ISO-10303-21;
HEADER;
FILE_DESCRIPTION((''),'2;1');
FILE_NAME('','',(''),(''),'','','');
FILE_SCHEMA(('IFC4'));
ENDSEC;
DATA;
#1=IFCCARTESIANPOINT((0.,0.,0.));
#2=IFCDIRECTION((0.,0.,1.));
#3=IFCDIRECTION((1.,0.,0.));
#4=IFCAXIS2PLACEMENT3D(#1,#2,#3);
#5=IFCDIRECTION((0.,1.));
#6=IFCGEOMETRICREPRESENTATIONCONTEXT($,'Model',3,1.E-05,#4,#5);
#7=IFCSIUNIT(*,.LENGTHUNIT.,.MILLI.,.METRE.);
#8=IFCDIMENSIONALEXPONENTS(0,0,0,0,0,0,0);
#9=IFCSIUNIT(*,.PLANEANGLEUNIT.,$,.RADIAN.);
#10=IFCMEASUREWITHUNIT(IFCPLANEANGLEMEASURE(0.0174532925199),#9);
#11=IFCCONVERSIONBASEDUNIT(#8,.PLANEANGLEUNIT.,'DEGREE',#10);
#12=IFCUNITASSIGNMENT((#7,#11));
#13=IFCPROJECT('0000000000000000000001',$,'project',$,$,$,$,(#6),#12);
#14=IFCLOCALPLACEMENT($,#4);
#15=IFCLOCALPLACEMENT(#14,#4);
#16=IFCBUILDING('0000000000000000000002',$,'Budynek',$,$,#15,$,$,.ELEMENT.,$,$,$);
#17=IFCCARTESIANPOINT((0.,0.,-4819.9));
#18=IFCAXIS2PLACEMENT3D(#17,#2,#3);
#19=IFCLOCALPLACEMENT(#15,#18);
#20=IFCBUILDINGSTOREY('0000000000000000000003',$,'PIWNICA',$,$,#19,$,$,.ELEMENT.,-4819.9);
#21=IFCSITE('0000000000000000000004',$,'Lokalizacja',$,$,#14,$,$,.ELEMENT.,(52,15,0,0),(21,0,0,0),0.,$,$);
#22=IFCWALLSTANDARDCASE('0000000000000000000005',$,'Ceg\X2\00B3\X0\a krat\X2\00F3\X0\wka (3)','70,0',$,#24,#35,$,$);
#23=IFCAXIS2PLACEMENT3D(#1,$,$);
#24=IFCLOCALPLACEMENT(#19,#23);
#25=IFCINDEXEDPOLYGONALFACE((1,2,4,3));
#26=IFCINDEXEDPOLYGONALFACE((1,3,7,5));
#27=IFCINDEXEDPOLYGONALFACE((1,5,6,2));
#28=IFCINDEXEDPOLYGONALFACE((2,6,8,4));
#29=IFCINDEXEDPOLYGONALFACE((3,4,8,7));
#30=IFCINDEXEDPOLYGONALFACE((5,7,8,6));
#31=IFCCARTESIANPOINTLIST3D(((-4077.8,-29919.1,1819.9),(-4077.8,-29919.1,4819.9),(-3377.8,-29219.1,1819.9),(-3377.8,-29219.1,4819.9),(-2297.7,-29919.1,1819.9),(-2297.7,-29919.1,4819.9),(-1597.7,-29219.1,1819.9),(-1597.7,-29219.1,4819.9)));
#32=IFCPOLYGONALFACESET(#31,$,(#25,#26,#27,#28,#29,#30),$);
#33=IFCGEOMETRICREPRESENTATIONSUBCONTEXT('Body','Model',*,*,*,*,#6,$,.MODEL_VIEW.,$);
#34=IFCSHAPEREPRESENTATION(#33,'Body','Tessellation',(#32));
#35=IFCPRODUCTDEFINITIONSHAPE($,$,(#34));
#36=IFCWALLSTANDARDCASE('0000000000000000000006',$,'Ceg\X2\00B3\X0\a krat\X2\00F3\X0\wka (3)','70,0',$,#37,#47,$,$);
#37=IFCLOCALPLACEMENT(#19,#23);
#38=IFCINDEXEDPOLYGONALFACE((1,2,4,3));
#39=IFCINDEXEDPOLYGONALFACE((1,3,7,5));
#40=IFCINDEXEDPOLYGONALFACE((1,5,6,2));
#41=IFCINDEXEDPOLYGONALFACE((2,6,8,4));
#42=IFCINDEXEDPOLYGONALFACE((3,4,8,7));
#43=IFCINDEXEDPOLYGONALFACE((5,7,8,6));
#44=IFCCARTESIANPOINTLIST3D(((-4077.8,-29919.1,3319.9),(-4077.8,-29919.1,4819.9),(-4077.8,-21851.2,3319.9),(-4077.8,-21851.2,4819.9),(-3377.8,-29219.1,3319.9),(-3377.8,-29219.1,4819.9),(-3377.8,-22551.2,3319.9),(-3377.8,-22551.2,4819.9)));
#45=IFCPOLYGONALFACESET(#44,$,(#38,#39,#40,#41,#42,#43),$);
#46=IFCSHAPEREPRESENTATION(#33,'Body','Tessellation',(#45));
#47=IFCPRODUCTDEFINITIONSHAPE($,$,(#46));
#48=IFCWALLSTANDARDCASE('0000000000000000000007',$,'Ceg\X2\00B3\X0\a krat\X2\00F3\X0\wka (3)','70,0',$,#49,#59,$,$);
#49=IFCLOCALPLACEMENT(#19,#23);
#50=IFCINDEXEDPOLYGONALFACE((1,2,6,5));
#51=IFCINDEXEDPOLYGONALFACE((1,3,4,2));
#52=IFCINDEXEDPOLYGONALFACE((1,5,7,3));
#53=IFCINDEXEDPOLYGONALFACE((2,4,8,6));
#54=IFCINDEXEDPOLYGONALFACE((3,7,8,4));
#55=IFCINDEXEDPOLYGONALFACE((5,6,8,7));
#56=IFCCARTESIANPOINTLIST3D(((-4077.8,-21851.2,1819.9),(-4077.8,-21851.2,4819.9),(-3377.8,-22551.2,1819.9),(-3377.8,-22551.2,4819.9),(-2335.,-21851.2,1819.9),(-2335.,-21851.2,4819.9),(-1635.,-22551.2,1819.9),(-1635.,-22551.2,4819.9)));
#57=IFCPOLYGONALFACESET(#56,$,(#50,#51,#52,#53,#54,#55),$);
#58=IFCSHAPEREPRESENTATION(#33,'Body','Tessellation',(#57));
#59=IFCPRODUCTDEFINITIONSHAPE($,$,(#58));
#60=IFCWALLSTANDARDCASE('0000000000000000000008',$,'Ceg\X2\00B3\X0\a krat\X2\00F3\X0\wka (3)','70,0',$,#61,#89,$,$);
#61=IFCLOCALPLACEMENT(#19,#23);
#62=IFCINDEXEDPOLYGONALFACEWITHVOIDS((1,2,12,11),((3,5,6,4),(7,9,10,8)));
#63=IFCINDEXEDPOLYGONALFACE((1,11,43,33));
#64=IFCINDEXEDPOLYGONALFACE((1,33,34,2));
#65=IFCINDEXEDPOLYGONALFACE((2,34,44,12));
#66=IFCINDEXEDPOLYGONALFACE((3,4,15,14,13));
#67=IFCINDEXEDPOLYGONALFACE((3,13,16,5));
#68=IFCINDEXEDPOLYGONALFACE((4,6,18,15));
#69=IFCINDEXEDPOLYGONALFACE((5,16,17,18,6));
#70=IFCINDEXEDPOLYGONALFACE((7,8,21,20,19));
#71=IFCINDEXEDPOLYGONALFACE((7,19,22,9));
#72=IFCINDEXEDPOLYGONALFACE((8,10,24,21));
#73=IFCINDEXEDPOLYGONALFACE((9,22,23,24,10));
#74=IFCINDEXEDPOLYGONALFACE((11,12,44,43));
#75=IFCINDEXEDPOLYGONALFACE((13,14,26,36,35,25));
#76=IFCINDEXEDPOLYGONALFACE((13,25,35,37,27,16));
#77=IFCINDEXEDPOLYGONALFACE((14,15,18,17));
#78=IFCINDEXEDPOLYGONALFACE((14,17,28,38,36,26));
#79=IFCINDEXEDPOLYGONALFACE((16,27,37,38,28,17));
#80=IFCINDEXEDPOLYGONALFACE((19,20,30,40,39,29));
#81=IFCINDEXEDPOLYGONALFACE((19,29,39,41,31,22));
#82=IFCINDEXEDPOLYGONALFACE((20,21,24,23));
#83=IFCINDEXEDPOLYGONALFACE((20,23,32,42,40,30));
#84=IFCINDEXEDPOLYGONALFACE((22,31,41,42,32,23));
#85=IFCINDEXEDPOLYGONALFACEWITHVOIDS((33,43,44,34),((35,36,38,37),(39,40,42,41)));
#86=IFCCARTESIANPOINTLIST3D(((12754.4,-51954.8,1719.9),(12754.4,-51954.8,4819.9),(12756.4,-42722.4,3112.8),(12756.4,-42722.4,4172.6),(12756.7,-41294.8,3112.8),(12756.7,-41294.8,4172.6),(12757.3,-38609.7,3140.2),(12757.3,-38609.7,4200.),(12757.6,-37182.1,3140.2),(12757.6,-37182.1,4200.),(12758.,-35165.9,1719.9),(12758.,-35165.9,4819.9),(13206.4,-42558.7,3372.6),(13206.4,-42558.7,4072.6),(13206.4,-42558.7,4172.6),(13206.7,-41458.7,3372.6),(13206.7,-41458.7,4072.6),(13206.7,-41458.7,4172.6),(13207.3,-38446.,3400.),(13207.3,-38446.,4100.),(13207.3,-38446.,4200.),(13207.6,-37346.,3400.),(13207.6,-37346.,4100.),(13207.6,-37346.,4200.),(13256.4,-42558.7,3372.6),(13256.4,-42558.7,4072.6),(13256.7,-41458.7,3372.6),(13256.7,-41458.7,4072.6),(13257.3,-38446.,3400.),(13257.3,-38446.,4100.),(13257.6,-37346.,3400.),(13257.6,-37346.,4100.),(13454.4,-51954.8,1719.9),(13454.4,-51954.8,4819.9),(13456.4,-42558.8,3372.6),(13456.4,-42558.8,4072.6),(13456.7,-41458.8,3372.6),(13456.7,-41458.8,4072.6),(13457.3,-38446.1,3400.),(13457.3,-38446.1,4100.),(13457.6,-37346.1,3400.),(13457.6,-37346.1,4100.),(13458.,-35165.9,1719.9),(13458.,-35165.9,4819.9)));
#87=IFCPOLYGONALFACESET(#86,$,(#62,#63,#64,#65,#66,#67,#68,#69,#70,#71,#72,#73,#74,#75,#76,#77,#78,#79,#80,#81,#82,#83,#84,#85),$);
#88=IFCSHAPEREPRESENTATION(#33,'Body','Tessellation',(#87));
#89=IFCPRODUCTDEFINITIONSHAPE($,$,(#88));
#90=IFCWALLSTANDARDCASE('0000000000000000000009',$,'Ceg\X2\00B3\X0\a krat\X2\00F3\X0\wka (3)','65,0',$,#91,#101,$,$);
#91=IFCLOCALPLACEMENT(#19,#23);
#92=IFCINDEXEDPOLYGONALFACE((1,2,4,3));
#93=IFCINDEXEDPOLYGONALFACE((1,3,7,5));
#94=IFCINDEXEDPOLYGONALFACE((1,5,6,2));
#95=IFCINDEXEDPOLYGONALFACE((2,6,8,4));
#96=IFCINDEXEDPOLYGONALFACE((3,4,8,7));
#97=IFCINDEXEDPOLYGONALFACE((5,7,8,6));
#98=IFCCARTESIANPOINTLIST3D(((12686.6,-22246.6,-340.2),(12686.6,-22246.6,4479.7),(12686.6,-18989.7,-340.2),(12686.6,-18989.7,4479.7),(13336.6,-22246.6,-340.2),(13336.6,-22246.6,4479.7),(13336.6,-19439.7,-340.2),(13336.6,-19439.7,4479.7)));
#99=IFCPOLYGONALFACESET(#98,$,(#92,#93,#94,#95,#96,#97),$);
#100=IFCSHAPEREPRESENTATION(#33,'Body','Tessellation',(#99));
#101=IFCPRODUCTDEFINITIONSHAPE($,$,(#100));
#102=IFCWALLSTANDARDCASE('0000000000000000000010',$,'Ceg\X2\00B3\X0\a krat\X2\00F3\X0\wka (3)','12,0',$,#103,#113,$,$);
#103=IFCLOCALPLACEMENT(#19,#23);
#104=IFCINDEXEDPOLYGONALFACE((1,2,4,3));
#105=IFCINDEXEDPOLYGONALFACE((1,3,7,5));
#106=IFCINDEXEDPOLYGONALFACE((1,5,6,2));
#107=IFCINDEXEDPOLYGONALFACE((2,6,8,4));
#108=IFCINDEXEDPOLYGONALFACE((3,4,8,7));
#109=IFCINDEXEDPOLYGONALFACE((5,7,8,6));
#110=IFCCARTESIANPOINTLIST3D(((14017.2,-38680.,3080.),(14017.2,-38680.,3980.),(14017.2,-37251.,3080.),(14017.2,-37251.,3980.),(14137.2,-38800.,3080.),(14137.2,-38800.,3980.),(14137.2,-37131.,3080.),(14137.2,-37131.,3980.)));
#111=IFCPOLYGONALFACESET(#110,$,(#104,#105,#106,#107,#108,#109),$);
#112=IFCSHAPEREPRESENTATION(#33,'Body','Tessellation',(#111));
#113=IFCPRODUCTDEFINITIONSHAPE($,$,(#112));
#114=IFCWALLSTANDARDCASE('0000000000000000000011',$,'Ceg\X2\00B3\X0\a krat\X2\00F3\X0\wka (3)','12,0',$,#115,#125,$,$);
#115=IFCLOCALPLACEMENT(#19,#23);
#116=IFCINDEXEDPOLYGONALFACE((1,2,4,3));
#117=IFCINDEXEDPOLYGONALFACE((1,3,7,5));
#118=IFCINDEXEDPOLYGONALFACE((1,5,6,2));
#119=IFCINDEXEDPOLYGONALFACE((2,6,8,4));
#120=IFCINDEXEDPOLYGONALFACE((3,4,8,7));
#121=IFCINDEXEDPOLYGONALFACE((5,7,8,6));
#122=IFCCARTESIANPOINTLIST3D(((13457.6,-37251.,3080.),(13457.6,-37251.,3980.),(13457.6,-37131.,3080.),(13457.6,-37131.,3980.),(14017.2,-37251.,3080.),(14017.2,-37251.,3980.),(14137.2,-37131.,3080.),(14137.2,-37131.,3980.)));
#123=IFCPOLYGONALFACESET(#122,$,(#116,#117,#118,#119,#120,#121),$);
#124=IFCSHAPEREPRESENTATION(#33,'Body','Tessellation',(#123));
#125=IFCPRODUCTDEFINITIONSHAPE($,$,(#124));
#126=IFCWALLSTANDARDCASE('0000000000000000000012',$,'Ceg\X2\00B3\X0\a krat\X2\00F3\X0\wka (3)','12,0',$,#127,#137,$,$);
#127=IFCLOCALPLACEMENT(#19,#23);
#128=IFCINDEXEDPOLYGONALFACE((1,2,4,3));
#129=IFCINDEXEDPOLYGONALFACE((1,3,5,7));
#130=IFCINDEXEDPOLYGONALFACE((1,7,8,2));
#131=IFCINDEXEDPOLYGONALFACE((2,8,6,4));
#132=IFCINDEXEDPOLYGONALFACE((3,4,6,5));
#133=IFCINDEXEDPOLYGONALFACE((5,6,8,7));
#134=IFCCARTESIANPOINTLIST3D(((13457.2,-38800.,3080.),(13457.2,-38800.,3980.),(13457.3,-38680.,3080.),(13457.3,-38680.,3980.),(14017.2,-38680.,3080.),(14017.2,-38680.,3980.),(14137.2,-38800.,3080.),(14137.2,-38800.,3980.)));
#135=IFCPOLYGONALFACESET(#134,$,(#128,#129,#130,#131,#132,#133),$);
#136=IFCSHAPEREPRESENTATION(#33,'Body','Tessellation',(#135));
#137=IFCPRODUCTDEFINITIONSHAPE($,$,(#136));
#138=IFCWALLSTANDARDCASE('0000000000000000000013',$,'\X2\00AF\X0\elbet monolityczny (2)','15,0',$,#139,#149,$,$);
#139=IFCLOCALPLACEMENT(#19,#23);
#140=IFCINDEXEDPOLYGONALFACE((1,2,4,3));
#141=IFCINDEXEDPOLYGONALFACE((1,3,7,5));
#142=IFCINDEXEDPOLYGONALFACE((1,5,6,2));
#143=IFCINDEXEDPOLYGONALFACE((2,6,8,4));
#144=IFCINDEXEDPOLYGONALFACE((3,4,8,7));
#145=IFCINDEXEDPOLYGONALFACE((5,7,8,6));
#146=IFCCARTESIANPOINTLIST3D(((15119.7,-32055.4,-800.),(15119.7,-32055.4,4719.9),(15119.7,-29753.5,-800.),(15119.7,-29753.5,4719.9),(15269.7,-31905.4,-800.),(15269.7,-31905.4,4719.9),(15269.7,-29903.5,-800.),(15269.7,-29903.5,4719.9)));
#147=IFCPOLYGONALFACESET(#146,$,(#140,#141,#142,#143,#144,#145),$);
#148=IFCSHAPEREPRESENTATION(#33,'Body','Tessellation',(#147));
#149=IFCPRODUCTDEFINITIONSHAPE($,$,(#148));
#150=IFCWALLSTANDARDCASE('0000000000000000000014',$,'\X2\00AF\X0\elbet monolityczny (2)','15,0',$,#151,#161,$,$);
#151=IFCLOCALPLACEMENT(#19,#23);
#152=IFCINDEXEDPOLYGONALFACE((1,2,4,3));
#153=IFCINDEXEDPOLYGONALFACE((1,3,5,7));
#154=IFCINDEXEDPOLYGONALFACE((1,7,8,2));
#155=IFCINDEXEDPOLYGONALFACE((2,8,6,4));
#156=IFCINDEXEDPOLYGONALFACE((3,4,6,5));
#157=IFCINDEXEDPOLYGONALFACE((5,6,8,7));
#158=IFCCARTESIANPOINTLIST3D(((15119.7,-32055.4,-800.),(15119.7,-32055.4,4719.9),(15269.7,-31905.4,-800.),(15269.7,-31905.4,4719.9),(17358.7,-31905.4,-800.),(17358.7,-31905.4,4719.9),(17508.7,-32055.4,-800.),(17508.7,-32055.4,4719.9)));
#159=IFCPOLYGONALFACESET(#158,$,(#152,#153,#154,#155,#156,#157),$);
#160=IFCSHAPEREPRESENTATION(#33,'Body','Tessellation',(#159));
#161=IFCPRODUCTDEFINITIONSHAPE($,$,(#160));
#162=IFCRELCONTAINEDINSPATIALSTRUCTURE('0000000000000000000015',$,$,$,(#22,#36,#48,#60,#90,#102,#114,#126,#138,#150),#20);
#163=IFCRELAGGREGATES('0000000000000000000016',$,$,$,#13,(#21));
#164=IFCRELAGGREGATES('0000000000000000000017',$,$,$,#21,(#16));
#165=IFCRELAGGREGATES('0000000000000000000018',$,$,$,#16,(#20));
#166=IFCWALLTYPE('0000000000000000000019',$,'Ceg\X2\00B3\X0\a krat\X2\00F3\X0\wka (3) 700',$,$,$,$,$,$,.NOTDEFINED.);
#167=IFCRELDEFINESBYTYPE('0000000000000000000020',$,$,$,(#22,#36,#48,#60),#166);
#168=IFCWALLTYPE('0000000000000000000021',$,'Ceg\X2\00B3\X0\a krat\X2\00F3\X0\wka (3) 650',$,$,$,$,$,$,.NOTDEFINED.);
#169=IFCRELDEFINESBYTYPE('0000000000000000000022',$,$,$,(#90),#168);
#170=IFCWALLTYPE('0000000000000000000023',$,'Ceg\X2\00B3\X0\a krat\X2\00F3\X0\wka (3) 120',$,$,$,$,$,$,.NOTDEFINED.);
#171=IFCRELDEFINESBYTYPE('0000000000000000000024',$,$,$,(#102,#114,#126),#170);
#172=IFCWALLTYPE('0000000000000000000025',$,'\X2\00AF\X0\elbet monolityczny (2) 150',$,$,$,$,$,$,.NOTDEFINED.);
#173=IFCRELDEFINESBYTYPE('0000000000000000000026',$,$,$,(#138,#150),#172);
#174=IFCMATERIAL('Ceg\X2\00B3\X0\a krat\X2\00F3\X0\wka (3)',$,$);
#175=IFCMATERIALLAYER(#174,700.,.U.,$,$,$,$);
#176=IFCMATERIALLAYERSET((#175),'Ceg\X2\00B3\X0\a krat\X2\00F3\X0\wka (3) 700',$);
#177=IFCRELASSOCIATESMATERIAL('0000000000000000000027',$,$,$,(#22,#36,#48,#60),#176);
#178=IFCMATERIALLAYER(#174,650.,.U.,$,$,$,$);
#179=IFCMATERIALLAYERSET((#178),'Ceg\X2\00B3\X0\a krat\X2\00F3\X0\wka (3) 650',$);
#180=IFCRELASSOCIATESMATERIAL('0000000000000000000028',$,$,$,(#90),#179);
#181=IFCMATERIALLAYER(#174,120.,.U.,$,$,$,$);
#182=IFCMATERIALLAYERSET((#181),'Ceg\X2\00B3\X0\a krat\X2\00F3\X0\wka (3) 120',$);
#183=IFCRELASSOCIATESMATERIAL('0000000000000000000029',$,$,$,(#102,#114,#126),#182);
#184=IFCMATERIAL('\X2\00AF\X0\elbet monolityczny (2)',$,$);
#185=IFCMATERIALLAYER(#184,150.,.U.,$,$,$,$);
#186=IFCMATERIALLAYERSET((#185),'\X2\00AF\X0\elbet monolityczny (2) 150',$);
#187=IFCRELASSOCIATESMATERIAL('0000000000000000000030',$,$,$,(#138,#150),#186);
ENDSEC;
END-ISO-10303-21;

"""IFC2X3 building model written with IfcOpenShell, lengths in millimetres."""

from ifc_helpers import new_model, entity, si_unit, converted_unit, direction, frame, origin_with_axes, origin_2d_with_axis, place, context, subcontext, project, spatial, polyline, rectangle, outline, extrude, material, layer, layer_set, layer_usage, type_object, element, save


model = new_model("IFC2X3")

# Units and contexts
model_context = context("Model", 3, precision=1e-05, world=origin_with_axes(), true_north=direction((0.0, 1.0)))
body_context = subcontext(model_context, "Body", "Model", "MODEL_VIEW")
ifc_project = project(units=[si_unit("LENGTHUNIT", "METRE", prefix="MILLI"), converted_unit("PLANEANGLEUNIT", "DEGREE", entity("IfcPlaneAngleMeasure", 0.0174532925199), si_unit("PLANEANGLEUNIT", "RADIAN"), dimensions=[0, 0, 0, 0, 0, 0, 0])], contexts=[model_context])

# Site, building, storey
site_placement = place(None, origin_with_axes())
site = spatial("IfcSite", under=ifc_project, at=site_placement, Name="Lokalizacja", CompositionType="ELEMENT", RefLatitude=(52, 15, 0, 0), RefLongitude=(21, 0, 0, 0), RefElevation=0.0)
building_placement = place(site_placement, origin_with_axes())
building = spatial("IfcBuilding", under=site, at=building_placement, Name="Budynek", CompositionType="ELEMENT")
storey_placement = place(building_placement, frame((0.0, 0.0, -4819.9), z_axis=(0.0, 0.0, 1.0), x_axis=(1.0, 0.0, 0.0)))
storey = spatial("IfcBuildingStorey", under=building, at=storey_placement, Name="PIWNICA", CompositionType="ELEMENT", Elevation=-4819.9)

# Shared definitions
ifc_material_1 = material(Name="¯elbet monolityczny (2)")

# Shared definitions
ifc_material_2 = material(Name="Ceg³a kratówka (3)")

# Walls
ifc_layer_1 = layer(ifc_material_2, 700.0, ventilated="UNKNOWN")
ifc_layer_set_1 = layer_set([ifc_layer_1], Name="Ceg³a kratówka (3) 700")
wall_type_1 = type_object("IfcWallType", Name="Ceg³a kratówka (3) 700", PredefinedType="NOTDEFINED")
ifc_layer_usage_1 = layer_usage(ifc_layer_set_1, "AXIS2", "NEGATIVE", 0.0)
wall_1_placement = place(storey_placement, frame((-3377.8, -29219.1, 1819.9), z_axis=(0.0, 0.0, 1.0), x_axis=(1.0, 0.0, 0.0)))
element("IfcWallStandardCase", 1, at=wall_1_placement, inside=storey, type_object=wall_type_1, material=ifc_layer_usage_1, Name="Ceg³a kratówka (3)", Description="70,0", context=body_context, shape_type="SweptSolid", body=[
    extrude(outline(polyline([(-700.0, -700.0), (1080.0, -700.0), (1780.0, 0.0), (0.0, 0.0), (-700.0, -700.0)])), origin_with_axes(), (0.0, 0.0, 1.0), 3000.0),
])
ifc_layer_usage_2 = layer_usage(ifc_layer_set_1, "AXIS2", "NEGATIVE", 0.0)
wall_2_placement = place(storey_placement, frame((-3377.8, -22551.2, 3319.9), z_axis=(0.0, 0.0, 1.0), x_axis=(0.0, -1.0, 0.0)))
element("IfcWallStandardCase", 2, at=wall_2_placement, inside=storey, type_object=wall_type_1, material=ifc_layer_usage_2, Name="Ceg³a kratówka (3)", Description="70,0", context=body_context, shape_type="SweptSolid", body=[
    extrude(outline(polyline([(-700.0, -700.0), (7367.9, -700.0), (6667.9, 0.0), (0.0, 0.0), (-700.0, -700.0)])), origin_with_axes(), (0.0, 0.0, 1.0), 1500.0),
])
ifc_layer_usage_3 = layer_usage(ifc_layer_set_1, "AXIS2", "NEGATIVE", 0.0)
wall_3_placement = place(storey_placement, frame((-1635.0, -22551.2, 1819.9), z_axis=(0.0, 0.0, 1.0), x_axis=(-1.0, 0.0, 0.0)))
element("IfcWallStandardCase", 3, at=wall_3_placement, inside=storey, type_object=wall_type_1, material=ifc_layer_usage_3, Name="Ceg³a kratówka (3)", Description="70,0", context=body_context, shape_type="SweptSolid", body=[
    extrude(outline(polyline([(700.0, -700.0), (2442.8, -700.0), (1742.8, 0.0), (0.0, 0.0), (700.0, -700.0)])), origin_with_axes(), (0.0, 0.0, 1.0), 3000.0),
])

# Wall, openings
ifc_layer_usage_4 = layer_usage(ifc_layer_set_1, "AXIS2", "POSITIVE", 0.0)
wall_4_placement = place(storey_placement, frame((12758.1, -34765.9, 1719.9), z_axis=(0.0, 0.0, 1.0), x_axis=(-0.000214, -1.0, 0.0)))
wall_4 = element("IfcWallStandardCase", 4, at=wall_4_placement, inside=storey, type_object=wall_type_1, material=ifc_layer_usage_4, Name="Ceg³a kratówka (3)", Description="70,0", context=body_context, shape_type="SweptSolid", body=[
    extrude(outline(polyline([(400.0, 0.0), (17188.9, 0.0), (17188.8, 700.0), (399.9, 700.0), (400.0, 0.0)])), origin_with_axes(), (0.0, 0.0, 1.0), 3100.0),
])
opening_1_placement = place(wall_4_placement, frame((7242.7, 0.0, 1652.7), z_axis=(0.0, 0.0, 1.0), x_axis=(1.0, 0.0, 0.0)))
element("IfcOpeningElement", 5, at=opening_1_placement, cuts=wall_4, context=body_context, shape_type="SweptSolid", body=[
    extrude(rectangle(XDim=1100.0, YDim=700.0, at=origin_2d_with_axis()), frame((0.0, 500.0, 350.0), z_axis=(0.0, -1.0, 0.0), x_axis=(-1.0, 0.0, 0.0)), (0.0, 0.0, -1.0), 900.0),
    extrude(rectangle(XDim=1100.0, YDim=700.0, at=origin_2d_with_axis()), frame((0.0, 500.0, 350.0), z_axis=(0.0, -1.0, 0.0), x_axis=(-1.0, 0.0, 0.0)), (0.0, 0.0, 1.0), 50.0),
    extrude(rectangle(XDim=1100.0, YDim=800.0, at=origin_2d_with_axis()), frame((0.0, 450.0, 400.0), z_axis=(0.0, 1.0, 0.0), x_axis=(-1.0, 0.0, 0.0)), (0.34202, 0.0, -0.939693), 700.0),
    extrude(rectangle(XDim=1100.0, YDim=800.0, at=origin_2d_with_axis()), frame((0.0, 450.0, 400.0), z_axis=(0.0, 1.0, 0.0), x_axis=(-1.0, 0.0, 0.0)), (-0.34202, 0.0, -0.939693), 700.0),
    extrude(rectangle(XDim=1100.0, YDim=800.0, at=origin_2d_with_axis()), frame((0.0, 450.0, 400.0), z_axis=(0.0, 1.0, 0.0), x_axis=(-1.0, 0.0, 0.0)), (0.300627, -0.476871, -0.825965), 1479.9),
    extrude(rectangle(XDim=1100.0, YDim=800.0, at=origin_2d_with_axis()), frame((0.0, 450.0, 400.0), z_axis=(0.0, 1.0, 0.0), x_axis=(-1.0, 0.0, 0.0)), (-0.300627, -0.476871, -0.825965), 1479.9),
])
opening_2_placement = place(wall_4_placement, frame((3130.0, 0.0, 1680.1), z_axis=(0.0, 0.0, 1.0), x_axis=(1.0, 0.0, 0.0)))
element("IfcOpeningElement", 6, at=opening_2_placement, cuts=wall_4, context=body_context, shape_type="SweptSolid", body=[
    extrude(rectangle(XDim=1100.0, YDim=700.0, at=origin_2d_with_axis()), frame((0.0, 500.0, 350.0), z_axis=(0.0, -1.0, 0.0), x_axis=(-1.0, 0.0, 0.0)), (0.0, 0.0, -1.0), 900.0),
    extrude(rectangle(XDim=1100.0, YDim=700.0, at=origin_2d_with_axis()), frame((0.0, 500.0, 350.0), z_axis=(0.0, -1.0, 0.0), x_axis=(-1.0, 0.0, 0.0)), (0.0, 0.0, 1.0), 50.0),
    extrude(rectangle(XDim=1100.0, YDim=800.0, at=origin_2d_with_axis()), frame((0.0, 450.0, 400.0), z_axis=(0.0, 1.0, 0.0), x_axis=(-1.0, 0.0, 0.0)), (0.34202, 0.0, -0.939693), 700.0),
    extrude(rectangle(XDim=1100.0, YDim=800.0, at=origin_2d_with_axis()), frame((0.0, 450.0, 400.0), z_axis=(0.0, 1.0, 0.0), x_axis=(-1.0, 0.0, 0.0)), (-0.34202, 0.0, -0.939693), 700.0),
    extrude(rectangle(XDim=1100.0, YDim=800.0, at=origin_2d_with_axis()), frame((0.0, 450.0, 400.0), z_axis=(0.0, 1.0, 0.0), x_axis=(-1.0, 0.0, 0.0)), (0.300627, -0.476871, -0.825965), 1479.9),
    extrude(rectangle(XDim=1100.0, YDim=800.0, at=origin_2d_with_axis()), frame((0.0, 450.0, 400.0), z_axis=(0.0, 1.0, 0.0), x_axis=(-1.0, 0.0, 0.0)), (-0.300627, -0.476871, -0.825965), 1479.9),
])

# Walls
ifc_layer_2 = layer(ifc_material_2, 650.0, ventilated="UNKNOWN")
ifc_layer_set_2 = layer_set([ifc_layer_2], Name="Ceg³a kratówka (3) 650")
ifc_layer_usage_5 = layer_usage(ifc_layer_set_2, "AXIS2", "NEGATIVE", 0.0)
wall_type_2 = type_object("IfcWallType", Name="Ceg³a kratówka (3) 650", PredefinedType="NOTDEFINED")
wall_5_placement = place(storey_placement, frame((12686.6, -22696.6, -340.2), z_axis=(0.0, 0.0, 1.0), x_axis=(0.0, 1.0, 0.0)))
element("IfcWallStandardCase", 7, at=wall_5_placement, inside=storey, type_object=wall_type_2, material=ifc_layer_usage_5, Name="Ceg³a kratówka (3)", Description="65,0", context=body_context, shape_type="SweptSolid", body=[
    extrude(outline(polyline([(450.0, -650.0), (3256.9, -650.0), (3706.9, 0.0), (450.0, 0.0), (450.0, -650.0)])), origin_with_axes(), (0.0, 0.0, 1.0), 4819.9),
])
ifc_layer_3 = layer(ifc_material_2, 120.0, ventilated="UNKNOWN")
ifc_layer_set_3 = layer_set([ifc_layer_3], Name="Ceg³a kratówka (3) 120")
ifc_layer_usage_6 = layer_usage(ifc_layer_set_3, "AXIS2", "NEGATIVE", 0.0)
wall_type_3 = type_object("IfcWallType", Name="Ceg³a kratówka (3) 120", PredefinedType="NOTDEFINED")
wall_6_placement = place(storey_placement, frame((14017.2, -38680.0, 3080.0), z_axis=(0.0, 0.0, 1.0), x_axis=(0.0, 1.0, 0.0)))
element("IfcWallStandardCase", 8, at=wall_6_placement, inside=storey, type_object=wall_type_3, material=ifc_layer_usage_6, Name="Ceg³a kratówka (3)", Description="12,0", context=body_context, shape_type="SweptSolid", body=[
    extrude(outline(polyline([(-120.0, -120.0), (1549.0, -120.0), (1429.0, 0.0), (0.0, 0.0), (-120.0, -120.0)])), origin_with_axes(), (0.0, 0.0, 1.0), 900.0),
])
ifc_layer_usage_7 = layer_usage(ifc_layer_set_3, "AXIS2", "NEGATIVE", 0.0)
wall_7_placement = place(storey_placement, frame((14017.2, -37251.0, 3080.0), z_axis=(0.0, 0.0, 1.0), x_axis=(-1.0, 0.0, 0.0)))
element("IfcWallStandardCase", 9, at=wall_7_placement, inside=storey, type_object=wall_type_3, material=ifc_layer_usage_7, Name="Ceg³a kratówka (3)", Description="12,0", context=body_context, shape_type="SweptSolid", body=[
    extrude(outline(polyline([(-120.0, -120.0), (559.6, -120.0), (559.6, 0.0), (0.0, 0.0), (-120.0, -120.0)])), origin_with_axes(), (0.0, 0.0, 1.0), 900.0),
])
ifc_layer_usage_8 = layer_usage(ifc_layer_set_3, "AXIS2", "POSITIVE", 0.0)
wall_8_placement = place(storey_placement, frame((14017.2, -38680.0, 3080.0), z_axis=(0.0, 0.0, 1.0), x_axis=(-1.0, 0.0, 0.0)))
element("IfcWallStandardCase", 10, at=wall_8_placement, inside=storey, type_object=wall_type_3, material=ifc_layer_usage_8, Name="Ceg³a kratówka (3)", Description="12,0", context=body_context, shape_type="SweptSolid", body=[
    extrude(outline(polyline([(0.0, 0.0), (559.9, 0.0), (559.9, 120.0), (-120.0, 120.0), (0.0, 0.0)])), origin_with_axes(), (0.0, 0.0, 1.0), 900.0),
])
ifc_layer_4 = layer(ifc_material_1, 150.0, ventilated="UNKNOWN")
ifc_layer_set_4 = layer_set([ifc_layer_4], Name="¯elbet monolityczny (2) 150")
ifc_layer_usage_9 = layer_usage(ifc_layer_set_4, "AXIS2", "POSITIVE", 0.0)
wall_type_4 = type_object("IfcWallType", Name="¯elbet monolityczny (2) 150", PredefinedType="NOTDEFINED")
wall_9_placement = place(storey_placement, frame((15119.7, -29903.5, -800.0), z_axis=(0.0, 0.0, 1.0), x_axis=(0.0, -1.0, 0.0)))
element("IfcWallStandardCase", 11, at=wall_9_placement, inside=storey, type_object=wall_type_4, material=ifc_layer_usage_9, Name="¯elbet monolityczny (2)", Description="15,0", context=body_context, shape_type="SweptSolid", body=[
    extrude(outline(polyline([(-150.0, 0.0), (2152.0, 0.0), (2002.0, 150.0), (0.0, 150.0), (-150.0, 0.0)])), origin_with_axes(), (0.0, 0.0, 1.0), 5519.9),
])
ifc_layer_usage_10 = layer_usage(ifc_layer_set_4, "AXIS2", "NEGATIVE", 0.0)
wall_10_placement = place(storey_placement, frame((15119.7, -31905.4, -800.0), z_axis=(0.0, 0.0, 1.0), x_axis=(1.0, 0.0, 0.0)))
element("IfcWallStandardCase", 12, at=wall_10_placement, inside=storey, type_object=wall_type_4, material=ifc_layer_usage_10, Name="¯elbet monolityczny (2)", Description="15,0", context=body_context, shape_type="SweptSolid", body=[
    extrude(outline(polyline([(0.0, -150.0), (2389.0, -150.0), (2239.0, 0.0), (150.0, 0.0), (0.0, -150.0)])), origin_with_axes(), (0.0, 0.0, 1.0), 5519.9),
])

save(model, "model.ifc")
